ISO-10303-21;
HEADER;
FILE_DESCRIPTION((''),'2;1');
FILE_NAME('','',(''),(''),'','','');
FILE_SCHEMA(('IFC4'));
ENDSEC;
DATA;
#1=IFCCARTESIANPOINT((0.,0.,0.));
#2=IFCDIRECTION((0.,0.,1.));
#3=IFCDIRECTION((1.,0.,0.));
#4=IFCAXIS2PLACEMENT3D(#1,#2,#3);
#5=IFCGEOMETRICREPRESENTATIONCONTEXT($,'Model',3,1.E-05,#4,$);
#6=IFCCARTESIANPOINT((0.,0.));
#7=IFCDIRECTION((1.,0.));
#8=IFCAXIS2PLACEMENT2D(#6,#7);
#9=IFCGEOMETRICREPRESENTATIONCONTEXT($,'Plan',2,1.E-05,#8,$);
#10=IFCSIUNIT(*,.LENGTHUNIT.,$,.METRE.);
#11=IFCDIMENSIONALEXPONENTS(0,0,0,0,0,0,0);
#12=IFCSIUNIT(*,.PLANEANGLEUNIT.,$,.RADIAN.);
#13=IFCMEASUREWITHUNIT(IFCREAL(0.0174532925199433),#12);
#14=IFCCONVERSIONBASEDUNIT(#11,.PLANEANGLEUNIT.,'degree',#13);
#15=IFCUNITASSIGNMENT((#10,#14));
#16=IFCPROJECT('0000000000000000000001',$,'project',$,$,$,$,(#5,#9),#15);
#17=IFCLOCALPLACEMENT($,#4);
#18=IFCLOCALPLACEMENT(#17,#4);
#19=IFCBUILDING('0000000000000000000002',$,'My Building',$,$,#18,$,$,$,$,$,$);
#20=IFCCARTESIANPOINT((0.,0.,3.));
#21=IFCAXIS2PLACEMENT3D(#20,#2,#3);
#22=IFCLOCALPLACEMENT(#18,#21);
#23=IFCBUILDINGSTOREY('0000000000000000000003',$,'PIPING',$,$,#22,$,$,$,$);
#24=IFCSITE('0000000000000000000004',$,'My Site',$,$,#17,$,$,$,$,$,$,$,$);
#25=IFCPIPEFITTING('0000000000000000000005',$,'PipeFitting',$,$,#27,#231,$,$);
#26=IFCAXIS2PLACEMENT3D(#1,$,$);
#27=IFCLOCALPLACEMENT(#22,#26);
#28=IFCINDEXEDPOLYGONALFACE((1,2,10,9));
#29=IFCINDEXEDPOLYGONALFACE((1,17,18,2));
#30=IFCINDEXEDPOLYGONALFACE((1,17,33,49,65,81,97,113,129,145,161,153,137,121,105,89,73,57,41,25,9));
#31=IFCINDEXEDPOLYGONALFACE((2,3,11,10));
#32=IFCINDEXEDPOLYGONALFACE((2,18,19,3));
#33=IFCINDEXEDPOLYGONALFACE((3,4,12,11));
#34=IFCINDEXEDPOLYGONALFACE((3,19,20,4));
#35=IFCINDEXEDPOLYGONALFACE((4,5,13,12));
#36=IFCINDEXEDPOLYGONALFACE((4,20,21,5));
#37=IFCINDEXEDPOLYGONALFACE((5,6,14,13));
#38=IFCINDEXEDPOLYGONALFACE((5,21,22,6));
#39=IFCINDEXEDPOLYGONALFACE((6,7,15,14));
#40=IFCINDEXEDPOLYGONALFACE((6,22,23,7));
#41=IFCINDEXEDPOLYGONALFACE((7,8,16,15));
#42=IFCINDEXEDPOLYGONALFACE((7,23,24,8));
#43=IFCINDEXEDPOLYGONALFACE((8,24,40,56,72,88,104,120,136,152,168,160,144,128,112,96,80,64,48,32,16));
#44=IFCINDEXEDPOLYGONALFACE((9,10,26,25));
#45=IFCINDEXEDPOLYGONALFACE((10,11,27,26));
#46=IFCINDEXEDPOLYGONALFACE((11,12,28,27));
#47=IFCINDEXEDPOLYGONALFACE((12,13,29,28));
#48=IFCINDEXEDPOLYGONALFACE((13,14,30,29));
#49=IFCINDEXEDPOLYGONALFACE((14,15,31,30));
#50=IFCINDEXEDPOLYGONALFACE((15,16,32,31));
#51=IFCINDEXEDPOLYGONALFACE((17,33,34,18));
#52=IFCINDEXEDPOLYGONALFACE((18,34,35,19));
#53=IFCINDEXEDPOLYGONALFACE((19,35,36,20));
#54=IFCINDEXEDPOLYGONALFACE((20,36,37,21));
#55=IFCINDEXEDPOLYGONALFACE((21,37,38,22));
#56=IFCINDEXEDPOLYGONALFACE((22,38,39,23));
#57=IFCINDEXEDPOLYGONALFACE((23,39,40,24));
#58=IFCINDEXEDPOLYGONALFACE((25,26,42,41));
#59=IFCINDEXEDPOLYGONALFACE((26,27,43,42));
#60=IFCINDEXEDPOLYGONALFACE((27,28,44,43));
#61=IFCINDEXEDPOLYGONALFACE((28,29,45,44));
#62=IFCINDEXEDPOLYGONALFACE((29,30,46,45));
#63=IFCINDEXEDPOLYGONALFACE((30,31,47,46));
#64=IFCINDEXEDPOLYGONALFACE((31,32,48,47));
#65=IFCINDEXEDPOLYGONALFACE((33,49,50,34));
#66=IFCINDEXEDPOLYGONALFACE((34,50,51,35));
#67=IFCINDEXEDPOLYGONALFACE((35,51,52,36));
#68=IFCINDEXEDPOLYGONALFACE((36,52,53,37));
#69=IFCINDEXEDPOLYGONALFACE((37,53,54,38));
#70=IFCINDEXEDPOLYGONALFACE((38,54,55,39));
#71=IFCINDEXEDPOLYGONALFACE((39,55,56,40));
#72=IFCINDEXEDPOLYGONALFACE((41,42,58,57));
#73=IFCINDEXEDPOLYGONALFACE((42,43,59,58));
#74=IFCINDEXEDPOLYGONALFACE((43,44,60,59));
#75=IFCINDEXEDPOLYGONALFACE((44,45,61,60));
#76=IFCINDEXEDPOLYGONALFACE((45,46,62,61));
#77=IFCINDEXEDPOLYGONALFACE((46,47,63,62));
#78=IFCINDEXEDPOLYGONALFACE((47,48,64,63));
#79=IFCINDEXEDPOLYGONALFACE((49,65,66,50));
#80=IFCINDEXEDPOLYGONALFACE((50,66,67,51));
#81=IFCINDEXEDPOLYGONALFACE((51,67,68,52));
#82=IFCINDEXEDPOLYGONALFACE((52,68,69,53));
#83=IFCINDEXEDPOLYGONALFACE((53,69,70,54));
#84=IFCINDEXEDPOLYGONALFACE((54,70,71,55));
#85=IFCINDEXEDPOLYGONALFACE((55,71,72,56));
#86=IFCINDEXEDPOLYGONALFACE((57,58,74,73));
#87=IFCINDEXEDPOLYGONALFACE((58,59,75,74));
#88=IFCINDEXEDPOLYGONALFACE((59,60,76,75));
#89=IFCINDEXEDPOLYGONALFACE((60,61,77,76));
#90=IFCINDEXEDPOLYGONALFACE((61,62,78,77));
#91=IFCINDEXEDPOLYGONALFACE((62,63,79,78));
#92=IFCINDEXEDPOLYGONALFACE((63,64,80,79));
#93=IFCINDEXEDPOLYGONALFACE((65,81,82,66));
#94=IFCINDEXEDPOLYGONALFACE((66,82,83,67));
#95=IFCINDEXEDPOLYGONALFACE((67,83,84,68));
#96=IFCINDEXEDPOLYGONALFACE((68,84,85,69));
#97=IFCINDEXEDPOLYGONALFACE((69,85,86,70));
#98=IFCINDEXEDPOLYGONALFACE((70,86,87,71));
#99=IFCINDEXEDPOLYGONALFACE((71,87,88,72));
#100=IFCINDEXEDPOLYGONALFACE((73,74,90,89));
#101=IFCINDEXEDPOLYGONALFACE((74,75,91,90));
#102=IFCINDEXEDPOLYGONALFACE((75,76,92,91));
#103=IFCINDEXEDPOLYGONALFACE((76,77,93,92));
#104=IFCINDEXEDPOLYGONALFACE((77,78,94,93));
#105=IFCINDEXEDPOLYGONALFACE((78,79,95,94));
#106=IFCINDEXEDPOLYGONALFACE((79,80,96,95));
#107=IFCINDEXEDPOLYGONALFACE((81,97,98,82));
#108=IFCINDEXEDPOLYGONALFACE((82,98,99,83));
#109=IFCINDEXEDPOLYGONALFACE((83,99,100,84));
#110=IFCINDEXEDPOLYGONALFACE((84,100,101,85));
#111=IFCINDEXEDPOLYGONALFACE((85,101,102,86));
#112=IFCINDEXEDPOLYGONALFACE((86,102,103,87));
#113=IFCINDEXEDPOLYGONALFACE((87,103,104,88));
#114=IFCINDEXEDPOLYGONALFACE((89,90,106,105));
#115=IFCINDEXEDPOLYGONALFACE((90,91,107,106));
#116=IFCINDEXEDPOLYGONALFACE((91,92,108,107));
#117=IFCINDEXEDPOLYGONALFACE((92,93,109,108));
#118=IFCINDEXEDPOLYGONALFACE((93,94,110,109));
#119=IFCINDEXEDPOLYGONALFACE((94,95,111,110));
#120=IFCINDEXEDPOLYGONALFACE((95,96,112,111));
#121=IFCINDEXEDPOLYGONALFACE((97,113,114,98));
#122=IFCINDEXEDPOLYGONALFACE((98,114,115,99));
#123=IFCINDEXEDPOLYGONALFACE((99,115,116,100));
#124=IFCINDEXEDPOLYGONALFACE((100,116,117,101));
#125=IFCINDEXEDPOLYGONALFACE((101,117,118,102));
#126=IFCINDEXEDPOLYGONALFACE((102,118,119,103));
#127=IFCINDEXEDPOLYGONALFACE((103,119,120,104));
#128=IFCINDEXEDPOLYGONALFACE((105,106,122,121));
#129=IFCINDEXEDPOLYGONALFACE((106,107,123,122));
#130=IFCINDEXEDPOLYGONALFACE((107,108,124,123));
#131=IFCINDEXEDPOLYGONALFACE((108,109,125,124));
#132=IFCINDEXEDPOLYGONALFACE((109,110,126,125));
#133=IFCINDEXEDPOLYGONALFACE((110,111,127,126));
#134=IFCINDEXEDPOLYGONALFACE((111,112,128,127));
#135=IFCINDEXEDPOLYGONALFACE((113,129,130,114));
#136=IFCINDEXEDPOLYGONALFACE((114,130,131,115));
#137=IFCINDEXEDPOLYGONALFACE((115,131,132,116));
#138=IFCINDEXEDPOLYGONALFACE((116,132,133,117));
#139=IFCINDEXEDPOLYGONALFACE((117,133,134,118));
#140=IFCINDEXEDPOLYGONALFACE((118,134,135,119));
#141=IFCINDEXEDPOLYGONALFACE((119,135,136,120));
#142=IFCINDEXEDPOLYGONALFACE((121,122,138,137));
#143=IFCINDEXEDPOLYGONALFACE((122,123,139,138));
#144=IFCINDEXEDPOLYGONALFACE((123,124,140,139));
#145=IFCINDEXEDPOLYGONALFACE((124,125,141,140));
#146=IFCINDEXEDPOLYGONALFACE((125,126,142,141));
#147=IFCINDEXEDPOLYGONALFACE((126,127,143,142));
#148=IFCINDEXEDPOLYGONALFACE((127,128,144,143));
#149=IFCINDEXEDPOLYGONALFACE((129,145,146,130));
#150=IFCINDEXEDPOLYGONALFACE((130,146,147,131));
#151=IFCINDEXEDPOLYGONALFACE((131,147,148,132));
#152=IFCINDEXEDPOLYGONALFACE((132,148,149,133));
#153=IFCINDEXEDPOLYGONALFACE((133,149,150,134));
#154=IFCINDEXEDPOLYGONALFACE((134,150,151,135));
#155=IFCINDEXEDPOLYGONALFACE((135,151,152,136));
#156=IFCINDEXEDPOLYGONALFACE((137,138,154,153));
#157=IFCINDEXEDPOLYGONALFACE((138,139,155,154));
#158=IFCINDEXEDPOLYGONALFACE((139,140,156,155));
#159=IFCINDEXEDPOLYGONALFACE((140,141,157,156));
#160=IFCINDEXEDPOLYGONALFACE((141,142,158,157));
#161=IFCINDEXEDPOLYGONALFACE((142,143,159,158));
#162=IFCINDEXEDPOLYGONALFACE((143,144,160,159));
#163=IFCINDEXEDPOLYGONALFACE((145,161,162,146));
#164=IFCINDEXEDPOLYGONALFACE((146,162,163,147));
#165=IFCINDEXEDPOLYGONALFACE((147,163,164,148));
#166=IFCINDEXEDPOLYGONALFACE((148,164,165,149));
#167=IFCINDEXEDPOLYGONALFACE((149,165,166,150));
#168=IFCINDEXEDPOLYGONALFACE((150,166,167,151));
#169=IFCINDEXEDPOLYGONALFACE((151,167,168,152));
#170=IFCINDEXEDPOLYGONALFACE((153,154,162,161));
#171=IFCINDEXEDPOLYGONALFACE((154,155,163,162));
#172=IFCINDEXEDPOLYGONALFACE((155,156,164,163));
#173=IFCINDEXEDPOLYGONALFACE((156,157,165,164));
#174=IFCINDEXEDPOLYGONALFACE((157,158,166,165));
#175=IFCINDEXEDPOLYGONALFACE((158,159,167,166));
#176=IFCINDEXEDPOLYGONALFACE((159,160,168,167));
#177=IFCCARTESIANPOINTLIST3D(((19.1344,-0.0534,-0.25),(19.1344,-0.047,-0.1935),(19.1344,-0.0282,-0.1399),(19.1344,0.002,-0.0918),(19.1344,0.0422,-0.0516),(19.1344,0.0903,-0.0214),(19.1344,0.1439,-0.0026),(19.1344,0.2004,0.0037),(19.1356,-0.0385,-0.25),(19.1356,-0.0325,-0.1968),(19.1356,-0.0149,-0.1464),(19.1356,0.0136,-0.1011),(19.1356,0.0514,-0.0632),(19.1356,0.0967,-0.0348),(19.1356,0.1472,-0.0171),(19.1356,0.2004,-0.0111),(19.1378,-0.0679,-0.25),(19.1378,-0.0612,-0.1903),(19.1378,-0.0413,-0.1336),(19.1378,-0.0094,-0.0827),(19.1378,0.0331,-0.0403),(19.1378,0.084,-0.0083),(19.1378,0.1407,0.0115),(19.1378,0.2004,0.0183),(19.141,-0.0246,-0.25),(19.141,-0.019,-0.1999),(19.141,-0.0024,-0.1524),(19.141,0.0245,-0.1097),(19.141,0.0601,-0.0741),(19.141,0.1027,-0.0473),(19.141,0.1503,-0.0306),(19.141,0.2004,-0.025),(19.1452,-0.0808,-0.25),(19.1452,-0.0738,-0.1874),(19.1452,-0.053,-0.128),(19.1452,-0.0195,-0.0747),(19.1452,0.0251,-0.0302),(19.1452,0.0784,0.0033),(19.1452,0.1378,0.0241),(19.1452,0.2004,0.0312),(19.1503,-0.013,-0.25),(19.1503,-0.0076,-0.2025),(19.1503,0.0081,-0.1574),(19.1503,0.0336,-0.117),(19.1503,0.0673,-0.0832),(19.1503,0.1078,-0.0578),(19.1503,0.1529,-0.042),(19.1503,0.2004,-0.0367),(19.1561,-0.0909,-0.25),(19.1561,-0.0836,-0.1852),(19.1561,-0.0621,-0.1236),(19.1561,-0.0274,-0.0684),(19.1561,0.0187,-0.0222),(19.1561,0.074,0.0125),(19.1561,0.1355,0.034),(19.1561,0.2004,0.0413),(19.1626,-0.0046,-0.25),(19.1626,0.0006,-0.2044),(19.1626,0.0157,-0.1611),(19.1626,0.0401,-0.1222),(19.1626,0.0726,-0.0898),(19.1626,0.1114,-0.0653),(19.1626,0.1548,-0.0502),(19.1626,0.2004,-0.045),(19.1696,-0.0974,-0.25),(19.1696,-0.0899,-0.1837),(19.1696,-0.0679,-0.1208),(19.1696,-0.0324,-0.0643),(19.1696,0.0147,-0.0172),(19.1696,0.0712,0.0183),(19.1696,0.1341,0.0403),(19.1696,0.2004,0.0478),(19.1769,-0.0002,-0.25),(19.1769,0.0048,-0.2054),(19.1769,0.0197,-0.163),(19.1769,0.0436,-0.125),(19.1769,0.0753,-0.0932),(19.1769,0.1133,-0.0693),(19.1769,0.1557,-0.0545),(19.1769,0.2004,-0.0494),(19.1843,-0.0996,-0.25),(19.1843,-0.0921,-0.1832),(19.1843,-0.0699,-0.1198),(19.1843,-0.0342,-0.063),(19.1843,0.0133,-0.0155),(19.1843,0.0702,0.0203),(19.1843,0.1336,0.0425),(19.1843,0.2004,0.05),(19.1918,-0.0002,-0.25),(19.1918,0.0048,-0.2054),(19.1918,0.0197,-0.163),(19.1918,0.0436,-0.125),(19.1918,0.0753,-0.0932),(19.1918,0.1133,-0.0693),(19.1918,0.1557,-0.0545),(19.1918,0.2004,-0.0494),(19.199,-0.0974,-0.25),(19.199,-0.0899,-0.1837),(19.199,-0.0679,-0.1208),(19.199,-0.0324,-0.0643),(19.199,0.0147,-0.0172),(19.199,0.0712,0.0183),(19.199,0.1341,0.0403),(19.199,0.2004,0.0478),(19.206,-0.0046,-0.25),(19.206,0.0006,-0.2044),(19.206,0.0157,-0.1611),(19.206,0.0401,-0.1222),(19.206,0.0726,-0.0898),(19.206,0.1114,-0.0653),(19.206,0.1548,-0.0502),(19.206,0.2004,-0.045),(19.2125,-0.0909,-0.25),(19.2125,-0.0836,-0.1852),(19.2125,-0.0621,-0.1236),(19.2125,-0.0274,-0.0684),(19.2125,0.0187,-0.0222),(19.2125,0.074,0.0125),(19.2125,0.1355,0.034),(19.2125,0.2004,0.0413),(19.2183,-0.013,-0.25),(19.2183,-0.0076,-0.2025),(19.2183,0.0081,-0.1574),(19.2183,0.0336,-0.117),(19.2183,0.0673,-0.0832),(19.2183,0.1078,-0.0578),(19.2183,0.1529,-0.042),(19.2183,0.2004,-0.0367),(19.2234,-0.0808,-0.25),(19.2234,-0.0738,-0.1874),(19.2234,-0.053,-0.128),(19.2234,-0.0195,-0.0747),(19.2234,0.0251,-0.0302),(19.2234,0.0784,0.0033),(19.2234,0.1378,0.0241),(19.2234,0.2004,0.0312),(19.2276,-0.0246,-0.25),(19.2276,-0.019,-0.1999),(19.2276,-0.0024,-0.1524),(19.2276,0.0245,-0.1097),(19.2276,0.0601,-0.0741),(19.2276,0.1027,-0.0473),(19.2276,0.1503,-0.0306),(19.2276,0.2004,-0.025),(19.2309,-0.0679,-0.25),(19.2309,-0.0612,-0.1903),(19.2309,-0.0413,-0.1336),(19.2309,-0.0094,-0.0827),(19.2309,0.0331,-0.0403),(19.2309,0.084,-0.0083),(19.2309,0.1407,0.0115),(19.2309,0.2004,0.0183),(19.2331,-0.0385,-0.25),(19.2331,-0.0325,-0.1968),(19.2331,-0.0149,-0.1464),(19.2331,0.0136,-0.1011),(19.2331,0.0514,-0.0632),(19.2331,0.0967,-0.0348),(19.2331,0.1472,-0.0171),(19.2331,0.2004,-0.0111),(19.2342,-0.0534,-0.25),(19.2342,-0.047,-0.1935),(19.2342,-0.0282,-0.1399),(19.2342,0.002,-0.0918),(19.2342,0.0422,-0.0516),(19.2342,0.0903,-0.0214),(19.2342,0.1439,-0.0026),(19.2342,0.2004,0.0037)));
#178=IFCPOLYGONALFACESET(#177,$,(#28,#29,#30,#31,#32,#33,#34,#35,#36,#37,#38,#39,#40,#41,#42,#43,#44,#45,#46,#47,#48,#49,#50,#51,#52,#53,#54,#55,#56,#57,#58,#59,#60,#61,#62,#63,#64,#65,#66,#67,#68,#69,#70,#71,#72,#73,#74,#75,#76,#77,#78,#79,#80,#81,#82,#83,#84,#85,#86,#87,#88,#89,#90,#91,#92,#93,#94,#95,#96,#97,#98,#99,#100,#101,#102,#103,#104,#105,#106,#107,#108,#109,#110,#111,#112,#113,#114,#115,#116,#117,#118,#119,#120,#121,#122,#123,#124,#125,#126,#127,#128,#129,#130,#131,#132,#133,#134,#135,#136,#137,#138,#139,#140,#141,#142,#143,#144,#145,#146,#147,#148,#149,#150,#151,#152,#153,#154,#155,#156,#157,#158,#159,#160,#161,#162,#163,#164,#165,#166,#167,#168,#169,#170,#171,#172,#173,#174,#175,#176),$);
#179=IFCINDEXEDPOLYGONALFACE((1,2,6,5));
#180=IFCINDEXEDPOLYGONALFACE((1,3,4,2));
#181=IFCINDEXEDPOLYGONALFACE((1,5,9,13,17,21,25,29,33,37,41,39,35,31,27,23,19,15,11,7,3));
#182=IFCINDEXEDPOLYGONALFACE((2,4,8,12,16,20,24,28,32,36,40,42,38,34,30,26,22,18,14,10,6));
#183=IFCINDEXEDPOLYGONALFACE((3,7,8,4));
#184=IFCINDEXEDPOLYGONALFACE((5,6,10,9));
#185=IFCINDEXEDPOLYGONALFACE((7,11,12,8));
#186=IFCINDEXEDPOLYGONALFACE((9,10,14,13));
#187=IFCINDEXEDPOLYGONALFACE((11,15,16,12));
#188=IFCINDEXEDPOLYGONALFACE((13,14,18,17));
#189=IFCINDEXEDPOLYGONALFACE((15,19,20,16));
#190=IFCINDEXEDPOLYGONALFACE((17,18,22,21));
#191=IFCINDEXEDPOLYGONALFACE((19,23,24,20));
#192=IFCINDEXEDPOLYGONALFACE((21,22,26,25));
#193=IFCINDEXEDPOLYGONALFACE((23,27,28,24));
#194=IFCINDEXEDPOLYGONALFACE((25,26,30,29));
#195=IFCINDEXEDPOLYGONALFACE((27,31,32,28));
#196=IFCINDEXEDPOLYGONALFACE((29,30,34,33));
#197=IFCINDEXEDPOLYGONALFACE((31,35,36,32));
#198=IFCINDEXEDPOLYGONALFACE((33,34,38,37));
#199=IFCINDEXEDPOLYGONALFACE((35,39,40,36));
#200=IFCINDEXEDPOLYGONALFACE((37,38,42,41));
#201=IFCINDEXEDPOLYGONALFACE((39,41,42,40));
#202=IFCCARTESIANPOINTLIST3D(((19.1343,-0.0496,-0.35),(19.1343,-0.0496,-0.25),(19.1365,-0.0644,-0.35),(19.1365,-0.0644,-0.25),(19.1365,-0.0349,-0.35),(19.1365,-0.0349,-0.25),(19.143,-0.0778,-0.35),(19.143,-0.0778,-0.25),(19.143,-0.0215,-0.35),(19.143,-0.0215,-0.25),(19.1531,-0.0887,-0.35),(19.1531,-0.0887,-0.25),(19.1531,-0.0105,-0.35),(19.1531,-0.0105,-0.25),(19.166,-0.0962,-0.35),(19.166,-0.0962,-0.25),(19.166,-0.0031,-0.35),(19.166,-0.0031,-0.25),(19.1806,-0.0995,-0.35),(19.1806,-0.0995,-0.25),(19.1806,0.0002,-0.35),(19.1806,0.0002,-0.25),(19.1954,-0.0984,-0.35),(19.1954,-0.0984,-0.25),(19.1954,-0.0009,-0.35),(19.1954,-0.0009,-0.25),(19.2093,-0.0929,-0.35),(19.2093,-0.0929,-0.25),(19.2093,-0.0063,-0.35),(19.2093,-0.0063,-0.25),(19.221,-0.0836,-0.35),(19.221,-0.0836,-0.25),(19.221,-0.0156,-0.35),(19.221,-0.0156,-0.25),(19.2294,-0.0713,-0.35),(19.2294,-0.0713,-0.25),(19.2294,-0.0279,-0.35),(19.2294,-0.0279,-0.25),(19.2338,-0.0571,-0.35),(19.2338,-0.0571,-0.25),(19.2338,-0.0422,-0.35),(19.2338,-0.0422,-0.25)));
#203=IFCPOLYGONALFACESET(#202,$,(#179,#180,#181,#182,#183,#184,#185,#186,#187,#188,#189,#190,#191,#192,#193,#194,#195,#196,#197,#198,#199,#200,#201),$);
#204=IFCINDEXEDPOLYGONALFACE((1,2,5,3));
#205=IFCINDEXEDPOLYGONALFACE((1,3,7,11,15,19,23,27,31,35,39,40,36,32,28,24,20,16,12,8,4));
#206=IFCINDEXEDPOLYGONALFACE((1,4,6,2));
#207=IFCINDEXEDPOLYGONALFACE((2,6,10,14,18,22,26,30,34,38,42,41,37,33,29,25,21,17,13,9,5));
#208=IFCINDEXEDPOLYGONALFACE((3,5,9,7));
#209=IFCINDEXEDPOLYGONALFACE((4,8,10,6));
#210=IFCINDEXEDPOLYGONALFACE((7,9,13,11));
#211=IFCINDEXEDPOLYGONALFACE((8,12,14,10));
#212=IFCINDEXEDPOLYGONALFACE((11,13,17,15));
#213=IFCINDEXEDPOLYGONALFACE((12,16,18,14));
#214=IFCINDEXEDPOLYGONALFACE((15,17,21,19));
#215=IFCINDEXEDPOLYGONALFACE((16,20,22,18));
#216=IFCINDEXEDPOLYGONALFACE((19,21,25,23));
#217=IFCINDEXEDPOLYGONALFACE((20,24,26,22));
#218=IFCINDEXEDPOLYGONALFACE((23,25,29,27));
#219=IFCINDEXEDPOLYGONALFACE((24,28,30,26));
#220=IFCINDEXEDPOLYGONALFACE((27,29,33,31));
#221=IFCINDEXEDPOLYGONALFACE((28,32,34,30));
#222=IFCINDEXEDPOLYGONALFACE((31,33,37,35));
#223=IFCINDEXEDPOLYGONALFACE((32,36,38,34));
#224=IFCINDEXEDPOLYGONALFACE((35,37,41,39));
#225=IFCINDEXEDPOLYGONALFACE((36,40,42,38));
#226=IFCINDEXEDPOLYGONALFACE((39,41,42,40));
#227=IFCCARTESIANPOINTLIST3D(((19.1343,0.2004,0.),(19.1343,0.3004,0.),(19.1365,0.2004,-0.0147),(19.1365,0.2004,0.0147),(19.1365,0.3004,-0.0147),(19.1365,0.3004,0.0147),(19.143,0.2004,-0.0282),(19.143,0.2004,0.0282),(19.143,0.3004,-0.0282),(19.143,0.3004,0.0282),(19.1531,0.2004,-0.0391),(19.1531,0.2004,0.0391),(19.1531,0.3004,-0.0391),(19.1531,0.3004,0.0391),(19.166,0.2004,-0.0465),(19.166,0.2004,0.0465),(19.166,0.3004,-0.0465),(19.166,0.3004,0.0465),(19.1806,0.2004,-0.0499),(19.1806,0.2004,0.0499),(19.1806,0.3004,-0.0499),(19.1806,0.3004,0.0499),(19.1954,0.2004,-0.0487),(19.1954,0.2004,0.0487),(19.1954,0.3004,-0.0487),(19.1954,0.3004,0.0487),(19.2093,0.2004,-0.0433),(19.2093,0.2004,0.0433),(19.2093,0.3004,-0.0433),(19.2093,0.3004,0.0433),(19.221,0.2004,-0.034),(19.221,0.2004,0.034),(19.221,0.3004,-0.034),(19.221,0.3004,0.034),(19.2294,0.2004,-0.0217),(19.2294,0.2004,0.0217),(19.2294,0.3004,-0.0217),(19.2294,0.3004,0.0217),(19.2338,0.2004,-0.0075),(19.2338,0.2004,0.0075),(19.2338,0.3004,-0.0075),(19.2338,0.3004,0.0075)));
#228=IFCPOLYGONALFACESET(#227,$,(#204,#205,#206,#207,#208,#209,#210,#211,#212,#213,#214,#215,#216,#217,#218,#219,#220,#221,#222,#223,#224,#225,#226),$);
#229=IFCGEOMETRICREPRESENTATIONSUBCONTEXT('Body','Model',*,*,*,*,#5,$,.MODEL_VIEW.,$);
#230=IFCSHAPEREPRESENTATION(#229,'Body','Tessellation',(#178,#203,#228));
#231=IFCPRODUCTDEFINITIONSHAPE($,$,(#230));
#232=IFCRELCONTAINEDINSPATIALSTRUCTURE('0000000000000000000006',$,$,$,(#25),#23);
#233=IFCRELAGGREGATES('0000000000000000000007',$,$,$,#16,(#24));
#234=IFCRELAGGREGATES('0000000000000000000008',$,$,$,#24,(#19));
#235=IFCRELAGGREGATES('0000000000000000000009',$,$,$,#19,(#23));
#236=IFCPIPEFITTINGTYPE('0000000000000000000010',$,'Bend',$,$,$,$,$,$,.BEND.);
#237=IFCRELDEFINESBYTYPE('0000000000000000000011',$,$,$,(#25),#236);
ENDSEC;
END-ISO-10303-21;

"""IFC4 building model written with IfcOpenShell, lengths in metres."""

from ifc_helpers import new_model, entity, si_unit, converted_unit, frame, origin_with_axes, origin_2d_with_axis, place, context, subcontext, project, spatial, circle, extrude, source, transform, mapped, type_object, type_shapes, element, save


model = new_model("IFC4")

# Units and contexts
model_context = context("Model", 3, precision=1e-05, world=origin_with_axes())
plan_context = context("Plan", 2, precision=1e-05, world=origin_2d_with_axis())
body_context = subcontext(model_context, "Body", "Model", "MODEL_VIEW")
ifc_project = project(units=[si_unit("LENGTHUNIT", "METRE"), converted_unit("PLANEANGLEUNIT", "degree", entity("IfcReal", 0.0174532925199433), si_unit("PLANEANGLEUNIT", "RADIAN"), dimensions=[0, 0, 0, 0, 0, 0, 0])], contexts=[model_context, plan_context])

# Site, building, storey
site_placement = place(None, origin_with_axes())
site = spatial("IfcSite", under=ifc_project, at=site_placement, Name="My Site")
building_placement = place(site_placement, origin_with_axes())
building = spatial("IfcBuilding", under=site, at=building_placement, Name="My Building")
storey_placement = place(building_placement, frame((0.0, 0.0, 3.0), z_axis=(0.0, 0.0, 1.0), x_axis=(1.0, 0.0, 0.0)))
storey = spatial("IfcBuildingStorey", under=building, at=storey_placement, Name="PIPING")

# Pipe fitting
pipe_fitting_type = type_object("IfcPipeFittingType", Name="Bend", PredefinedType="BEND")
shared_shape = source(origin_with_axes(), body_context, "Body", "SolidModel", [
    entity("IfcSweptDiskSolid", entity("IfcIndexedPolyCurve", entity("IfcCartesianPointList3D", [[0.0, 0.0, 0.1], [0.0, -0.0732, 0.2768], [0.0, -0.25, 0.35]]), [entity("IfcArcIndex", [1, 2, 3])]), 0.05),
    extrude(circle(Radius=0.05), origin_with_axes(), (0.0, 0.0, 1.0), 0.1),
    extrude(circle(Radius=0.05), frame((0.0, -0.25, 0.35), z_axis=(0.0, -1.0, 0.0), x_axis=(1.0, 0.0, 0.0)), (0.0, 0.0, 1.0), 0.1),
])
type_shapes(pipe_fitting_type, [shared_shape])
for number, where, z_axis, x_axis, name in (
    (1, (19.1843, -0.0496, -0.35), (0.0, 0.0, 1.0), (-1.0, 0.0, 0.0), "PipeFitting"),
):
    element("IfcPipeFitting", number, at=place(storey_placement, frame(where, z_axis=z_axis, x_axis=x_axis)), inside=storey, type_object=pipe_fitting_type, Name=name, context=body_context, shape_type="MappedRepresentation", body=[
        mapped(shared_shape, transform((0.0, 0.0, 0.0), x_axis=(1.0, 0.0, 0.0), y_axis=(0.0, 1.0, 0.0), z_axis=(0.0, 0.0, 1.0), scale=1.0)),
    ])

save(model, "model.ifc")
